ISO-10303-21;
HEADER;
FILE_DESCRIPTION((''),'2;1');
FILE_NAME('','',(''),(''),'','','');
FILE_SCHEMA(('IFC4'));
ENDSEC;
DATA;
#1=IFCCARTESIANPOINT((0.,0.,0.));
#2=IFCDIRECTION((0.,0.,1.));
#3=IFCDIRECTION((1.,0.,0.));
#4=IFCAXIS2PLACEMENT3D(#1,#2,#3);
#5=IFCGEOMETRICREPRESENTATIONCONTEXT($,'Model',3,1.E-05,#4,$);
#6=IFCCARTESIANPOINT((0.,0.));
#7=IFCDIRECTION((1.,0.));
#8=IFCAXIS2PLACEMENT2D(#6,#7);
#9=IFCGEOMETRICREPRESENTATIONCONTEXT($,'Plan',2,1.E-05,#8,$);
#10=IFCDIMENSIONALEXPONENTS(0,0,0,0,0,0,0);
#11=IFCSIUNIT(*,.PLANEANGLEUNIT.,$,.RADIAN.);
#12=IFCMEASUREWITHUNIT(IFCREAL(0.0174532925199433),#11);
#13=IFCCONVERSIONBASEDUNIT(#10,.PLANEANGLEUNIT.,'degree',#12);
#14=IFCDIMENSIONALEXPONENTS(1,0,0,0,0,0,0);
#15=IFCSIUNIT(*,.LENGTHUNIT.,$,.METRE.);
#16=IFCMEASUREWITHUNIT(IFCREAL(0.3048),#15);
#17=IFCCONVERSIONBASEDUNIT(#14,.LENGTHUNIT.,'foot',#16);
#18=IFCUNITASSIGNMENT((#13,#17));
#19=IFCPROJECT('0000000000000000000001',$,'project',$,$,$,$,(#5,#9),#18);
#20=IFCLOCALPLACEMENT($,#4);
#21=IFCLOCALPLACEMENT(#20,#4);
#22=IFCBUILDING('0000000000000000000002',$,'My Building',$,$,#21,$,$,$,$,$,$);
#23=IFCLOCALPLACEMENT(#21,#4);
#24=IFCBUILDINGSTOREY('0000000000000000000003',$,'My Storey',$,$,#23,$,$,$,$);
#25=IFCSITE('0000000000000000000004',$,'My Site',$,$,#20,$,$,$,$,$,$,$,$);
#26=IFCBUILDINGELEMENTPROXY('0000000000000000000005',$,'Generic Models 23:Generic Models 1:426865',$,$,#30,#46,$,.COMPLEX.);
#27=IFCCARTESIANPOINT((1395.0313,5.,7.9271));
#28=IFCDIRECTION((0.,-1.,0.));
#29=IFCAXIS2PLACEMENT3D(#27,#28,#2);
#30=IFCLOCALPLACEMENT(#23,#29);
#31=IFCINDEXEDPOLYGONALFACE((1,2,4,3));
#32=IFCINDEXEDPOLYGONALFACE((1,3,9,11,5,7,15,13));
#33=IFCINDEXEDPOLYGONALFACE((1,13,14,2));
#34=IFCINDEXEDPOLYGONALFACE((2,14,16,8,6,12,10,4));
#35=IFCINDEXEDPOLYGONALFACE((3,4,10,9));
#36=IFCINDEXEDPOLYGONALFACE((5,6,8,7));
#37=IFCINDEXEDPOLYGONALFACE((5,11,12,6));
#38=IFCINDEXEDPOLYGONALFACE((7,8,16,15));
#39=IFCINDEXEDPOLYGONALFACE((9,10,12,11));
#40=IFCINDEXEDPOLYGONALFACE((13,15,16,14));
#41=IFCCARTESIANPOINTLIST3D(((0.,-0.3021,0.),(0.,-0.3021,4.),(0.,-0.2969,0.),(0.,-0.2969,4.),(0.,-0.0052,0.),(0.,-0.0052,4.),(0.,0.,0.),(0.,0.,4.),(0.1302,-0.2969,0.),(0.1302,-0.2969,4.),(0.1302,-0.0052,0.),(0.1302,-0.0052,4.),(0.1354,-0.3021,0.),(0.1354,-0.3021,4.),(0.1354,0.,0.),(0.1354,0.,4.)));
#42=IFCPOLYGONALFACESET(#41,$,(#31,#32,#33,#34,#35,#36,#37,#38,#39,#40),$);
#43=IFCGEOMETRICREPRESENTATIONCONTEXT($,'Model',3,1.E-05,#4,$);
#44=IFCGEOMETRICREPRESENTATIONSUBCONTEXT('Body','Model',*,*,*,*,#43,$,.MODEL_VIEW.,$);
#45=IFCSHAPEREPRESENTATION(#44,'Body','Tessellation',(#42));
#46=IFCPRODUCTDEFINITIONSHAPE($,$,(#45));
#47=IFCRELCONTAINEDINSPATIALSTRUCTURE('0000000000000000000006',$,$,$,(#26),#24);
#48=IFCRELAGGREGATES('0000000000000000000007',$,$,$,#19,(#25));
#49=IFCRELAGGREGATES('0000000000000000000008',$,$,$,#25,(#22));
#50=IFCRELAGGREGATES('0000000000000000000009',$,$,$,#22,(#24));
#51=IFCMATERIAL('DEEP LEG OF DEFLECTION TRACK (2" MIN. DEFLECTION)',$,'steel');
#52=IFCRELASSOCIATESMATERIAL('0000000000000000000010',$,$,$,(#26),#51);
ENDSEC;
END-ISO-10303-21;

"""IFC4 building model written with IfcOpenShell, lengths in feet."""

from ifc_helpers import new_model, entity, si_unit, converted_unit, frame, origin_with_axes, origin_2d_with_axis, place, context, subcontext, project, spatial, polyline, outline, extrude, material, element, save


model = new_model("IFC4")

# Units and contexts
model_context_1 = context("Model", 3, precision=1e-05, world=origin_with_axes())
plan_context = context("Plan", 2, precision=1e-05, world=origin_2d_with_axis())
model_context_2 = context("Model", 3, precision=1e-05, world=origin_with_axes())
body_context = subcontext(model_context_2, "Body", "Model", "MODEL_VIEW")
ifc_project = project(units=[converted_unit("PLANEANGLEUNIT", "degree", entity("IfcReal", 0.0174532925199433), si_unit("PLANEANGLEUNIT", "RADIAN"), dimensions=[0, 0, 0, 0, 0, 0, 0]), converted_unit("LENGTHUNIT", "foot", entity("IfcReal", 0.3048), si_unit("LENGTHUNIT", "METRE"), dimensions=[1, 0, 0, 0, 0, 0, 0])], contexts=[model_context_1, plan_context])

# Site, building, storey
site_placement = place(None, origin_with_axes())
site = spatial("IfcSite", under=ifc_project, at=site_placement, Name="My Site")
building_placement = place(site_placement, origin_with_axes())
building = spatial("IfcBuilding", under=site, at=building_placement, Name="My Building")
storey_placement = place(building_placement, origin_with_axes())
storey = spatial("IfcBuildingStorey", under=building, at=storey_placement, Name="My Storey")

# Building element proxy
ifc_material_1 = material(Name="DEEP LEG OF DEFLECTION TRACK (2\" MIN. DEFLECTION)", Category="steel")
proxy_1_placement = place(storey_placement, frame((1395.0313, 5.0, 7.9271), z_axis=(0.0, -1.0, 0.0), x_axis=(0.0, 0.0, 1.0)))
element("IfcBuildingElementProxy", 1, at=proxy_1_placement, inside=storey, material=ifc_material_1, Name="Generic Models 23:Generic Models 1:426865", PredefinedType="COMPLEX", context=body_context, shape_type="SweptSolid", body=[
    extrude(outline(polyline([(-0.0638, 0.1458), (0.0664, 0.1458), (0.0664, 0.151), (-0.069, 0.151), (-0.069, -0.151), (0.0664, -0.151), (0.0664, -0.1458), (-0.0638, -0.1458), (-0.0638, 0.1458)])), frame((0.0664, -0.151, 0.0), z_axis=(0.0, 0.0, -1.0), x_axis=(-1.0, 0.0, 0.0)), (0.0, 0.0, -1.0), 4.0),
])

save(model, "model.ifc")
